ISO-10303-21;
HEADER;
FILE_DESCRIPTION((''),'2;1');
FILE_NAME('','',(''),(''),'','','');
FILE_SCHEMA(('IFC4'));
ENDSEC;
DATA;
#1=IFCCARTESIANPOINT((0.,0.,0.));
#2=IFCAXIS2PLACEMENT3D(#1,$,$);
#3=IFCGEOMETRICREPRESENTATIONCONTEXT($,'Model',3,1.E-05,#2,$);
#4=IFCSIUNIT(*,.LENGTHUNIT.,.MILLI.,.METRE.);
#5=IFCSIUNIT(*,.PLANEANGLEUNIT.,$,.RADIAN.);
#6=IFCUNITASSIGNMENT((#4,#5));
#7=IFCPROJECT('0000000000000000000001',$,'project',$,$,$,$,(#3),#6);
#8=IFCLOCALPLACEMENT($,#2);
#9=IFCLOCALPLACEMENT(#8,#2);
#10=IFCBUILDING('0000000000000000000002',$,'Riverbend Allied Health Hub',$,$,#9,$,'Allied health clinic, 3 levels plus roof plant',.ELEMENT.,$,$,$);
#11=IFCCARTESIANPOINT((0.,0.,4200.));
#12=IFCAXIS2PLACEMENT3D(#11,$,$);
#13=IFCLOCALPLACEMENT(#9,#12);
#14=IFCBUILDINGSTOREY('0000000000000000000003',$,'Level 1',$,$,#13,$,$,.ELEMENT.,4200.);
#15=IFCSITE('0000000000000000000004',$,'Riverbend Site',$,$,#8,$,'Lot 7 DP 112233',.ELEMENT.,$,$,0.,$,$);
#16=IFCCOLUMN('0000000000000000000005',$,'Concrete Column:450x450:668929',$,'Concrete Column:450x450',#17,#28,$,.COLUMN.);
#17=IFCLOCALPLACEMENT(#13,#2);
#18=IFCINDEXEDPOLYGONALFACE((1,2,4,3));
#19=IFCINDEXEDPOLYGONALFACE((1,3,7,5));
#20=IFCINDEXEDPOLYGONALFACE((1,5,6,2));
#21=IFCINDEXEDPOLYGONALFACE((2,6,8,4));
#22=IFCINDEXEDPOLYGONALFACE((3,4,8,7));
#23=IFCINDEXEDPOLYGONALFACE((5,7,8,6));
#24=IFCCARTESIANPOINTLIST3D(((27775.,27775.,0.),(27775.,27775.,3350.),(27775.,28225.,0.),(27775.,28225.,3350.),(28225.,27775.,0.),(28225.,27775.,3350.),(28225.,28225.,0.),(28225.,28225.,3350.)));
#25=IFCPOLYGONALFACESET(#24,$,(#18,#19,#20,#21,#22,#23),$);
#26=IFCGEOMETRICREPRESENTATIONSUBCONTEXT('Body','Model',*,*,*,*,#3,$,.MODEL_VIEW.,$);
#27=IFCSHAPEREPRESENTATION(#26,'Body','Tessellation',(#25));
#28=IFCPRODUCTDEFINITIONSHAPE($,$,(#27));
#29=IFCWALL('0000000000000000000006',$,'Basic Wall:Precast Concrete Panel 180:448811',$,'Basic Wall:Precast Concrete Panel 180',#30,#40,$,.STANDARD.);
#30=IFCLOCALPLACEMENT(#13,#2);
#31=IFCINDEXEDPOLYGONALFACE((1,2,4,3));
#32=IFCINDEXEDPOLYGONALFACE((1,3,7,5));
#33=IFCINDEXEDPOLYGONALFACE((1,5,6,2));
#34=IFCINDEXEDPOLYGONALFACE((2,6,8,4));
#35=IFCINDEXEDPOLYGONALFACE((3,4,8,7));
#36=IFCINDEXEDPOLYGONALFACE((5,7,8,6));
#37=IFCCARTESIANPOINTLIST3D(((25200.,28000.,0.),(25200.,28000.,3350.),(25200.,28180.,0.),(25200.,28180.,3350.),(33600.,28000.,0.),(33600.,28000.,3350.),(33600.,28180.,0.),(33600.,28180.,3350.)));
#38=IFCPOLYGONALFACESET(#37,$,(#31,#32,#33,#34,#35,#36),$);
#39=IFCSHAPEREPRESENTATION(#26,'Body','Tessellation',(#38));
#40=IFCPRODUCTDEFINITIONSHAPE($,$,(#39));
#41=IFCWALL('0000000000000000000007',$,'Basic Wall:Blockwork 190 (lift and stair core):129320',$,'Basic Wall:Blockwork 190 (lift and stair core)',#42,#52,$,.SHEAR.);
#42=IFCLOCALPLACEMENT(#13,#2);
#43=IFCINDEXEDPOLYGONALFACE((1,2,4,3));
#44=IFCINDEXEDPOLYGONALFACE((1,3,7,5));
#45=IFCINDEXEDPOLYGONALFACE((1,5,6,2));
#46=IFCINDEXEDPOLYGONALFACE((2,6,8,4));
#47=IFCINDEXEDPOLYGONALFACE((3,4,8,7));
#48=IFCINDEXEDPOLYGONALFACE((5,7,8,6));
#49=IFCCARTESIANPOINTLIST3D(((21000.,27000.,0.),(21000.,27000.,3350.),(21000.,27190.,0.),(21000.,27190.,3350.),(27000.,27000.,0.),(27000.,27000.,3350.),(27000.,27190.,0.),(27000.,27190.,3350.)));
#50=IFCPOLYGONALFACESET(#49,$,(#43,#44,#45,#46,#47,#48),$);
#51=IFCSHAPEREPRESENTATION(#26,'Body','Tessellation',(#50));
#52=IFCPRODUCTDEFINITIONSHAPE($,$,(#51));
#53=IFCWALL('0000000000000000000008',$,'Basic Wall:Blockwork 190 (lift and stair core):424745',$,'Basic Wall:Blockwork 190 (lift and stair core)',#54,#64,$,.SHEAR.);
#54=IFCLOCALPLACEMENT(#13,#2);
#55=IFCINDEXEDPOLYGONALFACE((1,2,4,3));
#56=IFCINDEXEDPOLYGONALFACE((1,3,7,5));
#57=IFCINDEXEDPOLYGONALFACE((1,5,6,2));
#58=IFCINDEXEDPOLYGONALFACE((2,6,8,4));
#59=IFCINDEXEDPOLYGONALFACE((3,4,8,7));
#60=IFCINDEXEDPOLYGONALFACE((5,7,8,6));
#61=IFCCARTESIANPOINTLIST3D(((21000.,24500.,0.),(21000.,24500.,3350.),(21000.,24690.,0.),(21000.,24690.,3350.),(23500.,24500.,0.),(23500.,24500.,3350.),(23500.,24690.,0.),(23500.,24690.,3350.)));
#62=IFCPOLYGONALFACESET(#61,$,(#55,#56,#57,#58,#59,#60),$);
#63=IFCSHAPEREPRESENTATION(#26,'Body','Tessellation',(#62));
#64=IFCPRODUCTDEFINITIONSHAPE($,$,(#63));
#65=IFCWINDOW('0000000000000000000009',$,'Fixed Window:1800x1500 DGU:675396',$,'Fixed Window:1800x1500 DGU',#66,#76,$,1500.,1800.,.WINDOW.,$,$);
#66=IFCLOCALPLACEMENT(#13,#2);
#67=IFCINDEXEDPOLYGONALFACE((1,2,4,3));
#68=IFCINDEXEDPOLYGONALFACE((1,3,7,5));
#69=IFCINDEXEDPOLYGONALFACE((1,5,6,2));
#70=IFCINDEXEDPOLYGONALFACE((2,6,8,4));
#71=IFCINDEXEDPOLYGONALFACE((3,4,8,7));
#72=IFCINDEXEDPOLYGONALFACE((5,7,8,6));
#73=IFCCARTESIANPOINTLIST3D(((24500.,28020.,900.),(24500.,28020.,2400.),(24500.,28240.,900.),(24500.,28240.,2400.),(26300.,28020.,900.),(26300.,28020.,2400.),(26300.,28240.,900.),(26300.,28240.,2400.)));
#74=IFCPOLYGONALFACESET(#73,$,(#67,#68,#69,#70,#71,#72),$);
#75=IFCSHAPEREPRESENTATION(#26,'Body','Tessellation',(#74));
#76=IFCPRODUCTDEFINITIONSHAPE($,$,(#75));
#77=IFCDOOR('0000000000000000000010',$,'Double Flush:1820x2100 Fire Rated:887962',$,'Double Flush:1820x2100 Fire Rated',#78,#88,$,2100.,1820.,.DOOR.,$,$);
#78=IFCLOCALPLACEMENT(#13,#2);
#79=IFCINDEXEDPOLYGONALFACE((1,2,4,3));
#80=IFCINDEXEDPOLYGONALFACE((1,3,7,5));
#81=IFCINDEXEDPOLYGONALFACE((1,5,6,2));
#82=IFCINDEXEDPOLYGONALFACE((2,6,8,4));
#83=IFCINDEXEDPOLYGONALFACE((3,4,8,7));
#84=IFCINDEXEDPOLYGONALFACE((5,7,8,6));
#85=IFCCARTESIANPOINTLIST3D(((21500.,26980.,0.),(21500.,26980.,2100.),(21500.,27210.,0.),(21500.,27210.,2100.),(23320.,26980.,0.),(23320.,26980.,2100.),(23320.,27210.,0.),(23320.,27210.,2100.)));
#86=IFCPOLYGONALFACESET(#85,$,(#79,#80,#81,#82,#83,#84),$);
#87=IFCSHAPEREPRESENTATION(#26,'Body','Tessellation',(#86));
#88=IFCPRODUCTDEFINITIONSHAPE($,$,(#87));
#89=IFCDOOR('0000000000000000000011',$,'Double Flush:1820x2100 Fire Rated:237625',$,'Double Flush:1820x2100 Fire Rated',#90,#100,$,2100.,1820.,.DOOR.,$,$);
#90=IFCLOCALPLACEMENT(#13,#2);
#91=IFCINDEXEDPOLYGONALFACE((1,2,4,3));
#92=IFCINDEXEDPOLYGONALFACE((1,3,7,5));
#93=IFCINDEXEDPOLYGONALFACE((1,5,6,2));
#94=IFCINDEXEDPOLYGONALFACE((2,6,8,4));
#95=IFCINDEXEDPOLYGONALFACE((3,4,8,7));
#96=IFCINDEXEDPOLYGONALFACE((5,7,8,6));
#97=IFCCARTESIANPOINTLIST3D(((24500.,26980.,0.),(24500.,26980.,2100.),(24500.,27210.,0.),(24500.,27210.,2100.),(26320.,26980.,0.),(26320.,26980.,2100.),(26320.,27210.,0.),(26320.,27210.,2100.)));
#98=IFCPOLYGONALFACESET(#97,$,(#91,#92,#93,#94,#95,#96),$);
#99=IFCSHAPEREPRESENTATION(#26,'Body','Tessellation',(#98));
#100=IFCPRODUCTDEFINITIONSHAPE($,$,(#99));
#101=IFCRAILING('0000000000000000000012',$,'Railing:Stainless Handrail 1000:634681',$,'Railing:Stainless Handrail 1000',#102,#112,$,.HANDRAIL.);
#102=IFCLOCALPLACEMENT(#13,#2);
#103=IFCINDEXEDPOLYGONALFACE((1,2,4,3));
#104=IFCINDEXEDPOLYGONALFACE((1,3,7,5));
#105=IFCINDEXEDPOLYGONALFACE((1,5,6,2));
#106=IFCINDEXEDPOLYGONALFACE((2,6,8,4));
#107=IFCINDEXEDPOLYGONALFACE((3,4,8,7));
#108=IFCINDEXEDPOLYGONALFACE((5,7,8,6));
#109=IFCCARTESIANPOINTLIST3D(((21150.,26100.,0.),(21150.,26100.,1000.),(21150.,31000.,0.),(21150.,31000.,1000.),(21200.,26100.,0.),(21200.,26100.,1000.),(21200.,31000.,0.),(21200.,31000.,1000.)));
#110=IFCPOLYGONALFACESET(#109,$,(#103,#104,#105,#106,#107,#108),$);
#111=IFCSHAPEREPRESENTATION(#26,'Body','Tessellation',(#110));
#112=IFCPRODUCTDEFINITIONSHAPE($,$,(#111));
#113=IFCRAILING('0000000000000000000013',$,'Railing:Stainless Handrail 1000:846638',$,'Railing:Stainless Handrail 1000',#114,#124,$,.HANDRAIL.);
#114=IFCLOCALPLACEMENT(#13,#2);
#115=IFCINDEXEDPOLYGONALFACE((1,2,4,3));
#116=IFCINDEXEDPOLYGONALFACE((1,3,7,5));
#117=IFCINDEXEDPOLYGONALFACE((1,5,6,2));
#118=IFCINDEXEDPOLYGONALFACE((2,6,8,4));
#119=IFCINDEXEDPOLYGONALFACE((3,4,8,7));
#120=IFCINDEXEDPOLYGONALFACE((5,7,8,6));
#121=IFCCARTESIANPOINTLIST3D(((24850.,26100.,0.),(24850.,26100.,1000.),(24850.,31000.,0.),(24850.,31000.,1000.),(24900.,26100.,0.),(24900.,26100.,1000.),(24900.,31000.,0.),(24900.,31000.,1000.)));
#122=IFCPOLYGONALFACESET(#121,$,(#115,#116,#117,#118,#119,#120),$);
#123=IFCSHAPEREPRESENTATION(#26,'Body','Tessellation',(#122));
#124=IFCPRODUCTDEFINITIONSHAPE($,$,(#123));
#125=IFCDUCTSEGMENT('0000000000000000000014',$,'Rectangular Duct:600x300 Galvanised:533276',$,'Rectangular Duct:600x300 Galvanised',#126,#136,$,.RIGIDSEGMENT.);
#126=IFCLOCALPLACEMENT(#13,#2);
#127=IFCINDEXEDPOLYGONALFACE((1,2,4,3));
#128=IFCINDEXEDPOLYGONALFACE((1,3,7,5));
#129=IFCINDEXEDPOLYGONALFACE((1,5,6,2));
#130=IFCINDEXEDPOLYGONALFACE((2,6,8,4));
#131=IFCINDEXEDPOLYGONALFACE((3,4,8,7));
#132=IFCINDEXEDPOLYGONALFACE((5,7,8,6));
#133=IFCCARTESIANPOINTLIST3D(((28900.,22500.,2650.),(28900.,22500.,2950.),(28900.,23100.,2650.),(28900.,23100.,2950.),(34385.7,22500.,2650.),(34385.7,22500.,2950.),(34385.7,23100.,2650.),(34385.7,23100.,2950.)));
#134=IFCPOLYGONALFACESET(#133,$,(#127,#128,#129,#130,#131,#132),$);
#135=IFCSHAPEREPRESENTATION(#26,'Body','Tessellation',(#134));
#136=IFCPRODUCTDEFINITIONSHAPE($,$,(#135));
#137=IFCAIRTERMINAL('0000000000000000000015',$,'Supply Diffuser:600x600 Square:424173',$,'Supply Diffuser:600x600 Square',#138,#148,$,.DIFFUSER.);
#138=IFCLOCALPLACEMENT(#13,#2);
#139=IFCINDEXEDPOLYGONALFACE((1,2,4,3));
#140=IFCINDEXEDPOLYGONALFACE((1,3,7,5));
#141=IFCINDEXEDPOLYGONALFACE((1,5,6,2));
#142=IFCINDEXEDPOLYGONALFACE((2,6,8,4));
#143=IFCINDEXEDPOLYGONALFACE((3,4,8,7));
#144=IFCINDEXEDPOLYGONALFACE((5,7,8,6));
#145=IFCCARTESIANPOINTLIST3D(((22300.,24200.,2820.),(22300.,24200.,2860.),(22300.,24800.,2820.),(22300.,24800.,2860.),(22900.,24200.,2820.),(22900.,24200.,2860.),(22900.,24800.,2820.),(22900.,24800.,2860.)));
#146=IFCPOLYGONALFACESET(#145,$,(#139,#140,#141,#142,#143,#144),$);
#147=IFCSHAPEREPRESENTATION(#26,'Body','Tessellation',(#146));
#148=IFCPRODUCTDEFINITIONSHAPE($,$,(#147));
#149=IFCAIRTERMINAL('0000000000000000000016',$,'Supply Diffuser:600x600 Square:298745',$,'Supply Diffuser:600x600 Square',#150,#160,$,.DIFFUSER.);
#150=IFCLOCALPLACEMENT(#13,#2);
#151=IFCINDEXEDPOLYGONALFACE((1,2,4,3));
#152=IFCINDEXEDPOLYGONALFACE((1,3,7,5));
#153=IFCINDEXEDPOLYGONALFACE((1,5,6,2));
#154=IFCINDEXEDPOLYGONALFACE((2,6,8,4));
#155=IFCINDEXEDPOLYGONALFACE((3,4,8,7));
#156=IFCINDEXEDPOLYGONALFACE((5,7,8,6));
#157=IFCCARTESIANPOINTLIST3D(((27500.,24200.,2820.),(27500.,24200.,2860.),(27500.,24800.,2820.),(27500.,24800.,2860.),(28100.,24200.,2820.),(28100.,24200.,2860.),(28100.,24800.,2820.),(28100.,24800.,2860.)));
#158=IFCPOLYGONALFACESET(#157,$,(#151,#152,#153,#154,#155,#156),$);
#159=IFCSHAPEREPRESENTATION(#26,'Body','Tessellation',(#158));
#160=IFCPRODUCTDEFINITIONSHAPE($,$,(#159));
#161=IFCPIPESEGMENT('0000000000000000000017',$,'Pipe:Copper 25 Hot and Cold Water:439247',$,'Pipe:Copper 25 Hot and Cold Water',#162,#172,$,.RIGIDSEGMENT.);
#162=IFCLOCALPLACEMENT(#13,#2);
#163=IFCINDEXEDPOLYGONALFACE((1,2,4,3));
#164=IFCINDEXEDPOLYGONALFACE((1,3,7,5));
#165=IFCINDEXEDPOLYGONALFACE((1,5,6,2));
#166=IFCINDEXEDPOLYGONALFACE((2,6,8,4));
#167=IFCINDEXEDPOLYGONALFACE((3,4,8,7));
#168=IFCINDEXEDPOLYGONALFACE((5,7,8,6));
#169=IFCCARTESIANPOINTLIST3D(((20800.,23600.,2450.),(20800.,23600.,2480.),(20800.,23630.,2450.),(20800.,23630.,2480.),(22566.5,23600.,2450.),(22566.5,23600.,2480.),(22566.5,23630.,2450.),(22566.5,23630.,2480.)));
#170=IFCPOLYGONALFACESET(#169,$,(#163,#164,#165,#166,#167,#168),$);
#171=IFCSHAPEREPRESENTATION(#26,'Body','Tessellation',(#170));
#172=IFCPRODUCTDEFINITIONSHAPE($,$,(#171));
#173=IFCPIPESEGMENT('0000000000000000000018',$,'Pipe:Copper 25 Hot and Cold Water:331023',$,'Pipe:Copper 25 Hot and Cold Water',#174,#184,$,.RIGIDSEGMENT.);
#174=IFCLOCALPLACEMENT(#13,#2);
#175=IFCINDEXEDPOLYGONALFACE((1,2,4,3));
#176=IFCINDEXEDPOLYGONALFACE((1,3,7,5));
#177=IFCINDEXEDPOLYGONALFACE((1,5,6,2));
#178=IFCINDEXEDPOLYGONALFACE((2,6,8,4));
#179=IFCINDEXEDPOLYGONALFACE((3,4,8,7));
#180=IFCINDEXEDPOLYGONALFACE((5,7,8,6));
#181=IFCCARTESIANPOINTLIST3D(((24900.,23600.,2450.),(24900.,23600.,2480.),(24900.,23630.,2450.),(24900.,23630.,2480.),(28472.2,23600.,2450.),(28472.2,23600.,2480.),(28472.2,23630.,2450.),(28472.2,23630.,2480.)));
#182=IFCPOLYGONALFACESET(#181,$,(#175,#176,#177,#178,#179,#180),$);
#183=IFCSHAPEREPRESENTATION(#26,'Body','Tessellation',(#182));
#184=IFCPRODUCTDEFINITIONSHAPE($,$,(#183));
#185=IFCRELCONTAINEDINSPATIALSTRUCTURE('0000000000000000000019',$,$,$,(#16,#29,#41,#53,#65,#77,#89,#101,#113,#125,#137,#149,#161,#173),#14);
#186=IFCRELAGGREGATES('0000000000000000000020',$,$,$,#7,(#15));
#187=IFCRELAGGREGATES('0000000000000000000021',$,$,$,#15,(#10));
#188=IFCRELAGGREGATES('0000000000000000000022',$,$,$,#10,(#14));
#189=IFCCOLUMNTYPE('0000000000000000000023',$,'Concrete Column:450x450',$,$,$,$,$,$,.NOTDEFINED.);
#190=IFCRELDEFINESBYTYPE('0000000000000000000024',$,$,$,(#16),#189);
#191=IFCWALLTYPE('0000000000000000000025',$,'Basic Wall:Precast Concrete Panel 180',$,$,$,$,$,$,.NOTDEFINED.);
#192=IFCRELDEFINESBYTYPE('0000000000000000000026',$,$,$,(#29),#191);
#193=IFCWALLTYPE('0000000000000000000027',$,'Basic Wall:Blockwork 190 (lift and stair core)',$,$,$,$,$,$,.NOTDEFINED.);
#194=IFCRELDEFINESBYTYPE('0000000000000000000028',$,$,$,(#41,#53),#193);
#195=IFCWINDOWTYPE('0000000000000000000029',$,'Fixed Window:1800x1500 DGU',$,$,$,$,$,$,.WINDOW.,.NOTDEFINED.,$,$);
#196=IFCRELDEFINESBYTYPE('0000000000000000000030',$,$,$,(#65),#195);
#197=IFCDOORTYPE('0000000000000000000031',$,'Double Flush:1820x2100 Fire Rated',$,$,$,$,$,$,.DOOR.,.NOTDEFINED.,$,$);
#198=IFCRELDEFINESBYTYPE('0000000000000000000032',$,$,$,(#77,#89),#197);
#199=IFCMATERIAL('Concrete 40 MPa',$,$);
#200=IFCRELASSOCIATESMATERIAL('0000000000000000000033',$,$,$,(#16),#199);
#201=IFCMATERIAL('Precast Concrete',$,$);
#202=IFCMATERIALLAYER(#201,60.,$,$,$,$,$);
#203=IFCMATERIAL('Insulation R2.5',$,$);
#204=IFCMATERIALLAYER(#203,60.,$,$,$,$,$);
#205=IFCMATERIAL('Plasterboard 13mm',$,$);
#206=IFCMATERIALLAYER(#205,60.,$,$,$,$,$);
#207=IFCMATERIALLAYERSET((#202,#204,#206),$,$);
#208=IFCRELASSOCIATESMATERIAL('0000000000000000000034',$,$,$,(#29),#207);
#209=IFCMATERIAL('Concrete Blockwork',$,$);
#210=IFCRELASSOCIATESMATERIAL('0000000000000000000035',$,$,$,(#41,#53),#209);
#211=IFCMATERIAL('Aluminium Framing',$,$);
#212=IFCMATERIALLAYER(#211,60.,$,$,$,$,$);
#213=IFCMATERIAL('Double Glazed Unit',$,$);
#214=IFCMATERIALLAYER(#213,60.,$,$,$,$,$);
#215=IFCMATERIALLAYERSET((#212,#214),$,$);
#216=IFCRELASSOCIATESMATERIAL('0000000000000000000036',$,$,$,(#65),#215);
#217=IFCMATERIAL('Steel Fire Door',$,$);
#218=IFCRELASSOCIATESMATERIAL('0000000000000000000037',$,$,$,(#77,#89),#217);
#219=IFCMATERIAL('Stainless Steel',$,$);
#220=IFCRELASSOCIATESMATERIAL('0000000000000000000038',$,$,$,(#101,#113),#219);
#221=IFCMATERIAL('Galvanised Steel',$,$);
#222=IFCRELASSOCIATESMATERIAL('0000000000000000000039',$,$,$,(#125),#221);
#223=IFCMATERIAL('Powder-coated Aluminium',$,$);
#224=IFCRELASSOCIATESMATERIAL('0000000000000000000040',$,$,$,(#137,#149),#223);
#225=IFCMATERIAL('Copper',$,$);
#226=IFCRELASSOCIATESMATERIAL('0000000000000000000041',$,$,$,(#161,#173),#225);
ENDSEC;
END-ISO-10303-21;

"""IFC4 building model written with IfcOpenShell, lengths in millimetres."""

from ifc_helpers import new_model, si_unit, frame, frame_2d, origin, place, context, subcontext, project, spatial, rectangle, extrude, material, layer, layer_set, layer_usage, type_object, element, save


model = new_model("IFC4")

# Units and contexts
model_context = context("Model", 3, precision=1e-05, world=origin())
body_context = subcontext(model_context, "Body", "Model", "MODEL_VIEW")
ifc_project = project(units=[si_unit("LENGTHUNIT", "METRE", prefix="MILLI"), si_unit("PLANEANGLEUNIT", "RADIAN")], contexts=[model_context])

# Site, building, storey
site_placement = place(None, origin())
site = spatial("IfcSite", under=ifc_project, at=site_placement, Name="Riverbend Site", LongName="Lot 7 DP 112233", CompositionType="ELEMENT", RefElevation=0.0)
building_placement = place(site_placement, origin())
building = spatial("IfcBuilding", under=site, at=building_placement, Name="Riverbend Allied Health Hub", LongName="Allied health clinic, 3 levels plus roof plant", CompositionType="ELEMENT")
storey_placement = place(building_placement, frame((0.0, 0.0, 4200.0)))
storey = spatial("IfcBuildingStorey", under=building, at=storey_placement, Name="Level 1", CompositionType="ELEMENT", Elevation=4200.0)

# Column
ifc_material_1 = material(Name="Concrete 40 MPa")
column_type = type_object("IfcColumnType", Name="Concrete Column:450x450", PredefinedType="NOTDEFINED")
column_placement = place(storey_placement, frame((27775.0, 27775.0, 0.0)))
element("IfcColumn", 1, at=column_placement, inside=storey, type_object=column_type, material=ifc_material_1, Name="Concrete Column:450x450:668929", ObjectType="Concrete Column:450x450", PredefinedType="COLUMN", context=body_context, shape_type="SweptSolid", body=[
    extrude(rectangle(XDim=450.0, YDim=450.0, at=frame_2d((225.0, 225.0))), origin(), (0.0, 0.0, 1.0), 3350.0),
])

# Walls
ifc_material_2 = material(Name="Precast Concrete")
ifc_layer_1 = layer(ifc_material_2, 60.0)
ifc_material_3 = material(Name="Insulation R2.5")
ifc_layer_2 = layer(ifc_material_3, 60.0)
ifc_material_4 = material(Name="Plasterboard 13mm")
ifc_layer_3 = layer(ifc_material_4, 60.0)
ifc_layer_set_1 = layer_set([ifc_layer_1, ifc_layer_2, ifc_layer_3])
ifc_layer_usage_1 = layer_usage(ifc_layer_set_1, "AXIS2", "POSITIVE", 0.0)
wall_type_1 = type_object("IfcWallType", Name="Basic Wall:Precast Concrete Panel 180", PredefinedType="NOTDEFINED")
wall_1_placement = place(storey_placement, frame((25200.0, 28000.0, 0.0)))
element("IfcWall", 2, at=wall_1_placement, inside=storey, type_object=wall_type_1, material=ifc_layer_usage_1, Name="Basic Wall:Precast Concrete Panel 180:448811", ObjectType="Basic Wall:Precast Concrete Panel 180", PredefinedType="STANDARD", context=body_context, shape_type="SweptSolid", body=[
    extrude(rectangle(XDim=8400.0, YDim=180.0, at=frame_2d((4200.0, 90.0))), origin(), (0.0, 0.0, 1.0), 3350.0),
])
ifc_material_5 = material(Name="Concrete Blockwork")
wall_type_2 = type_object("IfcWallType", Name="Basic Wall:Blockwork 190 (lift and stair core)", PredefinedType="NOTDEFINED")
wall_2_placement = place(storey_placement, frame((21000.0, 27000.0, 0.0)))
element("IfcWall", 3, at=wall_2_placement, inside=storey, type_object=wall_type_2, material=ifc_material_5, Name="Basic Wall:Blockwork 190 (lift and stair core):129320", ObjectType="Basic Wall:Blockwork 190 (lift and stair core)", PredefinedType="SHEAR", context=body_context, shape_type="SweptSolid", body=[
    extrude(rectangle(XDim=6000.0, YDim=190.0, at=frame_2d((3000.0, 95.0))), origin(), (0.0, 0.0, 1.0), 3350.0),
])
wall_3_placement = place(storey_placement, frame((21000.0, 24500.0, 0.0)))
element("IfcWall", 4, at=wall_3_placement, inside=storey, type_object=wall_type_2, material=ifc_material_5, Name="Basic Wall:Blockwork 190 (lift and stair core):424745", ObjectType="Basic Wall:Blockwork 190 (lift and stair core)", PredefinedType="SHEAR", context=body_context, shape_type="SweptSolid", body=[
    extrude(rectangle(XDim=2500.0, YDim=190.0, at=frame_2d((1250.0, 95.0))), origin(), (0.0, 0.0, 1.0), 3350.0),
])

# Window
ifc_material_6 = material(Name="Aluminium Framing")
ifc_layer_4 = layer(ifc_material_6, 60.0)
ifc_material_7 = material(Name="Double Glazed Unit")
ifc_layer_5 = layer(ifc_material_7, 60.0)
ifc_layer_set_2 = layer_set([ifc_layer_4, ifc_layer_5])
ifc_layer_usage_2 = layer_usage(ifc_layer_set_2, "AXIS2", "POSITIVE", 0.0)
window_type = type_object("IfcWindowType", Name="Fixed Window:1800x1500 DGU", PartitioningType="NOTDEFINED", PredefinedType="WINDOW")
window_placement = place(storey_placement, frame((24500.0, 28020.0, 900.0)))
element("IfcWindow", 5, at=window_placement, inside=storey, type_object=window_type, material=ifc_layer_usage_2, Name="Fixed Window:1800x1500 DGU:675396", ObjectType="Fixed Window:1800x1500 DGU", OverallHeight=1500.0, OverallWidth=1800.0, PredefinedType="WINDOW", context=body_context, shape_type="SweptSolid", body=[
    extrude(rectangle(XDim=1800.0, YDim=220.0, at=frame_2d((900.0, 110.0))), origin(), (0.0, 0.0, 1.0), 1500.0),
])

# Doors
ifc_material_8 = material(Name="Steel Fire Door")
door_type = type_object("IfcDoorType", Name="Double Flush:1820x2100 Fire Rated", OperationType="NOTDEFINED", PredefinedType="DOOR")
for number, where, name in (
    (6, (21500.0, 26980.0, 0.0), "Double Flush:1820x2100 Fire Rated:887962"),
    (7, (24500.0, 26980.0, 0.0), "Double Flush:1820x2100 Fire Rated:237625"),
):
    element("IfcDoor", number, at=place(storey_placement, frame(where)), inside=storey, type_object=door_type, material=ifc_material_8, Name=name, ObjectType="Double Flush:1820x2100 Fire Rated", OverallHeight=2100.0, OverallWidth=1820.0, PredefinedType="DOOR", context=body_context, shape_type="SweptSolid", body=[
        extrude(rectangle(XDim=1820.0, YDim=230.0, at=frame_2d((910.0, 115.0))), origin(), (0.0, 0.0, 1.0), 2100.0),
    ])

# Railings
ifc_material_9 = material(Name="Stainless Steel")
for number, where, name in (
    (8, (21150.0, 26100.0, 0.0), "Railing:Stainless Handrail 1000:634681"),
    (9, (24850.0, 26100.0, 0.0), "Railing:Stainless Handrail 1000:846638"),
):
    element("IfcRailing", number, at=place(storey_placement, frame(where)), inside=storey, material=ifc_material_9, Name=name, ObjectType="Railing:Stainless Handrail 1000", PredefinedType="HANDRAIL", context=body_context, shape_type="SweptSolid", body=[
        extrude(rectangle(XDim=50.0, YDim=4900.0, at=frame_2d((25.0, 2450.0))), origin(), (0.0, 0.0, 1.0), 1000.0),
    ])

# Duct segment
ifc_material_10 = material(Name="Galvanised Steel")
duct_segment_placement = place(storey_placement, frame((28900.0, 22500.0, 2650.0)))
element("IfcDuctSegment", 10, at=duct_segment_placement, inside=storey, material=ifc_material_10, Name="Rectangular Duct:600x300 Galvanised:533276", ObjectType="Rectangular Duct:600x300 Galvanised", PredefinedType="RIGIDSEGMENT", context=body_context, shape_type="SweptSolid", body=[
    extrude(rectangle(XDim=5485.7, YDim=600.0, at=frame_2d((2742.8, 300.0))), origin(), (0.0, 0.0, 1.0), 300.0),
])

# Air terminals
ifc_material_11 = material(Name="Powder-coated Aluminium")
for number, where, name in (
    (11, (22300.0, 24200.0, 2820.0), "Supply Diffuser:600x600 Square:424173"),
    (12, (27500.0, 24200.0, 2820.0), "Supply Diffuser:600x600 Square:298745"),
):
    element("IfcAirTerminal", number, at=place(storey_placement, frame(where)), inside=storey, material=ifc_material_11, Name=name, ObjectType="Supply Diffuser:600x600 Square", PredefinedType="DIFFUSER", context=body_context, shape_type="SweptSolid", body=[
        extrude(rectangle(XDim=600.0, YDim=600.0, at=frame_2d((300.0, 300.0))), origin(), (0.0, 0.0, 1.0), 40.0),
    ])

# Pipe segments
ifc_material_12 = material(Name="Copper")
pipe_segment_1_placement = place(storey_placement, frame((20800.0, 23600.0, 2450.0)))
element("IfcPipeSegment", 13, at=pipe_segment_1_placement, inside=storey, material=ifc_material_12, Name="Pipe:Copper 25 Hot and Cold Water:439247", ObjectType="Pipe:Copper 25 Hot and Cold Water", PredefinedType="RIGIDSEGMENT", context=body_context, shape_type="SweptSolid", body=[
    extrude(rectangle(XDim=1766.5, YDim=30.0, at=frame_2d((883.2, 15.0))), origin(), (0.0, 0.0, 1.0), 30.0),
])
pipe_segment_2_placement = place(storey_placement, frame((24900.0, 23600.0, 2450.0)))
element("IfcPipeSegment", 14, at=pipe_segment_2_placement, inside=storey, material=ifc_material_12, Name="Pipe:Copper 25 Hot and Cold Water:331023", ObjectType="Pipe:Copper 25 Hot and Cold Water", PredefinedType="RIGIDSEGMENT", context=body_context, shape_type="SweptSolid", body=[
    extrude(rectangle(XDim=3572.2, YDim=30.0, at=frame_2d((1786.1, 15.0))), origin(), (0.0, 0.0, 1.0), 30.0),
])

save(model, "model.ifc")
